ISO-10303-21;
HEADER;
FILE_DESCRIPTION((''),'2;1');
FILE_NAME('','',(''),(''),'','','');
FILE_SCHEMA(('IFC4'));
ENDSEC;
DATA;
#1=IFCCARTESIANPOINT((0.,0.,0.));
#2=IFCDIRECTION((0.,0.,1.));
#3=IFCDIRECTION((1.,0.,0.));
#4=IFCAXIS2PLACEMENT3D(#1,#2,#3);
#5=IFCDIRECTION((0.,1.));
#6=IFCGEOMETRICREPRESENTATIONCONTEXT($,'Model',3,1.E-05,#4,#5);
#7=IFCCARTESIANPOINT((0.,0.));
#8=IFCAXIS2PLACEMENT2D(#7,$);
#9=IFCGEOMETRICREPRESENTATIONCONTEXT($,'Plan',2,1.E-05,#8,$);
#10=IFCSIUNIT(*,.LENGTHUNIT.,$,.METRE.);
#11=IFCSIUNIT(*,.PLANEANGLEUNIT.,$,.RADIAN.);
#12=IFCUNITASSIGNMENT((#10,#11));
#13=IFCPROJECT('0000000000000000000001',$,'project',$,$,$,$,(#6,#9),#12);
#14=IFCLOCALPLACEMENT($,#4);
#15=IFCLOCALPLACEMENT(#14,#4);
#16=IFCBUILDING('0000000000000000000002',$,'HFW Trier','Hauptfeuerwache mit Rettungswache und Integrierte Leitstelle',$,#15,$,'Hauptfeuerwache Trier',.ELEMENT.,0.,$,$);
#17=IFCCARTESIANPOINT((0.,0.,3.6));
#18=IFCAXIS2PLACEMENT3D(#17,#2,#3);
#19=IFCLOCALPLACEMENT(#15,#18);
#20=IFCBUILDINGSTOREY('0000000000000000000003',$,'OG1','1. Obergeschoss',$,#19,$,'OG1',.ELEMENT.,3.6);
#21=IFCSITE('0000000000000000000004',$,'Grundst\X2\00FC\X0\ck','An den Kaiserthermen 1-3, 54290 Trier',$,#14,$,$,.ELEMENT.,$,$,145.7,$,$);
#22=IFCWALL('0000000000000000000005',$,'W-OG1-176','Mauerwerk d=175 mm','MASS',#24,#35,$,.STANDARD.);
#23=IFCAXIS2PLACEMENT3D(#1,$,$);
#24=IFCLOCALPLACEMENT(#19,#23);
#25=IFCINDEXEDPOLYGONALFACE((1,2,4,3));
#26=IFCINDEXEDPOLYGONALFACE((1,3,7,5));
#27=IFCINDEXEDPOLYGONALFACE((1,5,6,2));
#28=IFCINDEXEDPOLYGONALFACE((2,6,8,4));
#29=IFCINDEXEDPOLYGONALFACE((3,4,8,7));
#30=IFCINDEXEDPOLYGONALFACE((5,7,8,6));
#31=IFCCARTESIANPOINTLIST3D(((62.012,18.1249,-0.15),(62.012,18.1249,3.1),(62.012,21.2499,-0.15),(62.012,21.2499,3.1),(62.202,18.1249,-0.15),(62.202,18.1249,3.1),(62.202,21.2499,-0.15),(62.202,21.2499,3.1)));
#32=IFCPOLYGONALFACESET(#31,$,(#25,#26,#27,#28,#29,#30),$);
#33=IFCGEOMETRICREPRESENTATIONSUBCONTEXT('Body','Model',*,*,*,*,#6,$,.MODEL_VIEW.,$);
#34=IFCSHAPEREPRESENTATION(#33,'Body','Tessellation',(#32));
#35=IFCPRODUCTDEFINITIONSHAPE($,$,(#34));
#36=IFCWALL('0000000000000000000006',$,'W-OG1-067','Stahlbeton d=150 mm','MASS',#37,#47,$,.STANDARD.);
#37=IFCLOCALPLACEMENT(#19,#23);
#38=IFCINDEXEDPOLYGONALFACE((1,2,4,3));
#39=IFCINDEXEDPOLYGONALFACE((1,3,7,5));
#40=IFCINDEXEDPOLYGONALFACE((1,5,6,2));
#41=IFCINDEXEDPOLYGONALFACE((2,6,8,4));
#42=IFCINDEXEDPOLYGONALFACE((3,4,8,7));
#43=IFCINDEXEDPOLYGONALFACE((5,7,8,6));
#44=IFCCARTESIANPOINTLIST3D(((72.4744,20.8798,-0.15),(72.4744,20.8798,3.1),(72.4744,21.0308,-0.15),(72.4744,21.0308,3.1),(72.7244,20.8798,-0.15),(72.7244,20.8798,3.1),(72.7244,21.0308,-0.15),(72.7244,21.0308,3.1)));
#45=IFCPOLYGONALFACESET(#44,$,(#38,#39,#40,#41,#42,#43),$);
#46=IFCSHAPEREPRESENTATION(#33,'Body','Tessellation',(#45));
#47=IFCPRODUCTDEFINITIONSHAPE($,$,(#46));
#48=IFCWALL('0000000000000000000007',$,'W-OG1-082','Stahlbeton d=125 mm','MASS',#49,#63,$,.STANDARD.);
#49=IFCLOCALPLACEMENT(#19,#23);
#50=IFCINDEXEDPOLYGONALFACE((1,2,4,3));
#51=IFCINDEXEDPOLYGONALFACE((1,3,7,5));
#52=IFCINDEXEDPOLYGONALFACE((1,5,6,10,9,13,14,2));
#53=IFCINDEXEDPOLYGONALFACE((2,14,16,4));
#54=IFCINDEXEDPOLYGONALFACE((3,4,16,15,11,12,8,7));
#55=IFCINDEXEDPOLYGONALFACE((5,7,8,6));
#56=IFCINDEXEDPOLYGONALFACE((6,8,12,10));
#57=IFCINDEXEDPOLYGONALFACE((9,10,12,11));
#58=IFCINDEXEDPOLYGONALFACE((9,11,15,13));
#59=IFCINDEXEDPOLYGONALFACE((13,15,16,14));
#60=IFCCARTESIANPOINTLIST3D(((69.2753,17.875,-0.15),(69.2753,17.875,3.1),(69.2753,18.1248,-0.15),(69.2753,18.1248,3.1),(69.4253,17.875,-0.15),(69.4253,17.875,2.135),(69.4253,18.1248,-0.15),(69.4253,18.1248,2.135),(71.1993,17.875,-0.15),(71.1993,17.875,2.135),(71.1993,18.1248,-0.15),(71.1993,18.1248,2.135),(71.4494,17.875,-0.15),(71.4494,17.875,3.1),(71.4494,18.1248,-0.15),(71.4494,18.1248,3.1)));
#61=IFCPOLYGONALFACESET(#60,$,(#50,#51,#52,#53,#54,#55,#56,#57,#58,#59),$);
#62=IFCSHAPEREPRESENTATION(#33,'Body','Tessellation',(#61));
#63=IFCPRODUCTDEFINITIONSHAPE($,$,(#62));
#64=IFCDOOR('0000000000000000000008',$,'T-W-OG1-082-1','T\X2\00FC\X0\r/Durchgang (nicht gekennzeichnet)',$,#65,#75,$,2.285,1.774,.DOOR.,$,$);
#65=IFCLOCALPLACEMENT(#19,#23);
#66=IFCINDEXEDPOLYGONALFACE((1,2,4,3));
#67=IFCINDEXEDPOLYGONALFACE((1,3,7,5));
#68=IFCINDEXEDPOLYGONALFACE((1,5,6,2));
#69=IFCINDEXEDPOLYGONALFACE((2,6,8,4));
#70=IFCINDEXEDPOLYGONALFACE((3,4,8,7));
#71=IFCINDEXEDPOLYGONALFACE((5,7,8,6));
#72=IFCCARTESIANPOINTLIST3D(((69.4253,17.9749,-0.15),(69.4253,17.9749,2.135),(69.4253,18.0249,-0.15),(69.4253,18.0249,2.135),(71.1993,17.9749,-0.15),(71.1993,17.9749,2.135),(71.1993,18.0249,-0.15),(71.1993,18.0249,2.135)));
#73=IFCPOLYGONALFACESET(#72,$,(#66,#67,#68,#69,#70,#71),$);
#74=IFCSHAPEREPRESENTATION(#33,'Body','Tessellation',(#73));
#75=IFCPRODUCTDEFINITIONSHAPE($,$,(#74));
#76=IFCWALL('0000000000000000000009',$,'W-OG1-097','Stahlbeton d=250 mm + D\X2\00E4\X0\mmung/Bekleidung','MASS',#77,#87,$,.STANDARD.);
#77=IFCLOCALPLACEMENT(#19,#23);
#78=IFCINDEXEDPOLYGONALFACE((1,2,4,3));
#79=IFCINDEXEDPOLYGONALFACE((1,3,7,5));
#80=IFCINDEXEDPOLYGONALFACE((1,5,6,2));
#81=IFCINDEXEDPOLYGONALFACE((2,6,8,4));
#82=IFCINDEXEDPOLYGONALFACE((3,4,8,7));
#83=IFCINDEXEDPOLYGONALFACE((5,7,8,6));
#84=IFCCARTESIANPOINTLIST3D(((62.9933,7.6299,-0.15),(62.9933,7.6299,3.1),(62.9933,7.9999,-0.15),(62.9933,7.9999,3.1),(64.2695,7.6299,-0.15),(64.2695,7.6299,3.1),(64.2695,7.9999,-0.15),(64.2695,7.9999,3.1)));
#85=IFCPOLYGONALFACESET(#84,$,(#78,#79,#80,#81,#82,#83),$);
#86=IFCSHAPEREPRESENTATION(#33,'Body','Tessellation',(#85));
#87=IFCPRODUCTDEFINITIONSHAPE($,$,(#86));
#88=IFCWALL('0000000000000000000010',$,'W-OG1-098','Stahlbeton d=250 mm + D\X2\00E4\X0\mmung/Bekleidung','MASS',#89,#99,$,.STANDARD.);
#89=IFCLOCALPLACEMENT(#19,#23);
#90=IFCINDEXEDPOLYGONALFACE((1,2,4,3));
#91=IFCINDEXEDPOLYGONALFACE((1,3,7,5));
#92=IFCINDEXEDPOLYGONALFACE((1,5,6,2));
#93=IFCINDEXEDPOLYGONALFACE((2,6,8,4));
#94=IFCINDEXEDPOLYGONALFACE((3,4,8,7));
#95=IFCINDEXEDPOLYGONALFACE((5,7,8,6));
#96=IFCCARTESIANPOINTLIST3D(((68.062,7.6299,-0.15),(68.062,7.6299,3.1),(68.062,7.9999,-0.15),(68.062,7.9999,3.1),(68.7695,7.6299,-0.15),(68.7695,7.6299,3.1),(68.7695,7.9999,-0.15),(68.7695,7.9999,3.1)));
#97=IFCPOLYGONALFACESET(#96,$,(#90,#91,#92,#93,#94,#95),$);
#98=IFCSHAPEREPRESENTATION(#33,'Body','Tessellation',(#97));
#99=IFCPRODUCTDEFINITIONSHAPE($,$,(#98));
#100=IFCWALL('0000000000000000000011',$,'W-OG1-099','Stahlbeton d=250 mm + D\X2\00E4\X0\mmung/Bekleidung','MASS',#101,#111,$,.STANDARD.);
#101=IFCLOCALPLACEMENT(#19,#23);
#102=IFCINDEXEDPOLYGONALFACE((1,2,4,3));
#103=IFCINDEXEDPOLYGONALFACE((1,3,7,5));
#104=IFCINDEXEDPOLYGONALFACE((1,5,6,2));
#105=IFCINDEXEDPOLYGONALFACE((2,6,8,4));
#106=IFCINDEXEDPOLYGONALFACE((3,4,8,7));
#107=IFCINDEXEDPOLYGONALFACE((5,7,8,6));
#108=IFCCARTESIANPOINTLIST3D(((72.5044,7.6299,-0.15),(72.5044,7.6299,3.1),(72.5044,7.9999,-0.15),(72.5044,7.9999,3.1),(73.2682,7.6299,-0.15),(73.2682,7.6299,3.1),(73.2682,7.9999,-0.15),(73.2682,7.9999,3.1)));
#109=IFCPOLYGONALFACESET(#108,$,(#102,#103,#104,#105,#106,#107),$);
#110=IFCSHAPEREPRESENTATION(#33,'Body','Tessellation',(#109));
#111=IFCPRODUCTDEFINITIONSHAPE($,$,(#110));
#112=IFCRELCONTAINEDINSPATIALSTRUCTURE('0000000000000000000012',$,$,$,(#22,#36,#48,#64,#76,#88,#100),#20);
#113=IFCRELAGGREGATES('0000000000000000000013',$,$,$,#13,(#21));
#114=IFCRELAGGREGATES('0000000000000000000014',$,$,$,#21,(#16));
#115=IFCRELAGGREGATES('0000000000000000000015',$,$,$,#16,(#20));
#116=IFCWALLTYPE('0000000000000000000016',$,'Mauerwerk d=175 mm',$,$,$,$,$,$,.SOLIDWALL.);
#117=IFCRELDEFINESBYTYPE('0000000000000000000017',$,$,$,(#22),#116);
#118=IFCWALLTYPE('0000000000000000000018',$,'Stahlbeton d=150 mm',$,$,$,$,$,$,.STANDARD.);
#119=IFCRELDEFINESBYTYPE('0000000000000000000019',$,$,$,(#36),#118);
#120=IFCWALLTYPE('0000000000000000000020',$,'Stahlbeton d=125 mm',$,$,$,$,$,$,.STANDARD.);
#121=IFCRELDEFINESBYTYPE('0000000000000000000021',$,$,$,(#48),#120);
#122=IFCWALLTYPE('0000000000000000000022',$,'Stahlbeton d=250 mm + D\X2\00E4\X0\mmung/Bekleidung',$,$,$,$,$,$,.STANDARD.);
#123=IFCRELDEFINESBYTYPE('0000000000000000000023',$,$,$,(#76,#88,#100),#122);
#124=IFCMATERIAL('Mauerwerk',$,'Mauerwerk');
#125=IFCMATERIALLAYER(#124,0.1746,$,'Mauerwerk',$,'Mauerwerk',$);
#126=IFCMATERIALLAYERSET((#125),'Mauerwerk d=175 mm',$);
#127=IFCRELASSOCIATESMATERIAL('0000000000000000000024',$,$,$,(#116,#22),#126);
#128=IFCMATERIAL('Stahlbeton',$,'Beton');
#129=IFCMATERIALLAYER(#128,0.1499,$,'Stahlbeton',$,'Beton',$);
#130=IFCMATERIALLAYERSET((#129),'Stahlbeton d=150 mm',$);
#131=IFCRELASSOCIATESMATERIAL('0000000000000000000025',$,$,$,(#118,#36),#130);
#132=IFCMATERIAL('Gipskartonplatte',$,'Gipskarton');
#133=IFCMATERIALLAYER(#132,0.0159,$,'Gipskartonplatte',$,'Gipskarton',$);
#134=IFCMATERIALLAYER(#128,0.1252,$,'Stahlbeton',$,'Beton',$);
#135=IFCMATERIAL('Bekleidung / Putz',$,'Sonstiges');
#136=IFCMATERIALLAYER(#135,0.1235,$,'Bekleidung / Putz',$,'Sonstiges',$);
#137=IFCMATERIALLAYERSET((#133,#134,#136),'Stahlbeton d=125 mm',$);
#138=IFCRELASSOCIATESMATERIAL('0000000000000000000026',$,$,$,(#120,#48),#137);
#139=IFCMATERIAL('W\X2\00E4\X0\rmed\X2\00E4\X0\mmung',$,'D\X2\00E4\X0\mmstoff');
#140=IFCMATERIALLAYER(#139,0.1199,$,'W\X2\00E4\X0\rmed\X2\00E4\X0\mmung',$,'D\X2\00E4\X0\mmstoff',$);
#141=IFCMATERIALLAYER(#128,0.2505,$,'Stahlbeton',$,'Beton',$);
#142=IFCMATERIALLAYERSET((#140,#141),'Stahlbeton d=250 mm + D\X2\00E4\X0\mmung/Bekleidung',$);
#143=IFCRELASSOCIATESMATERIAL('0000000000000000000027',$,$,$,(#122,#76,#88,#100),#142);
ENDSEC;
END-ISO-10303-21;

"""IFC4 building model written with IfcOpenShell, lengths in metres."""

from ifc_helpers import new_model, si_unit, direction, frame, frame_2d, origin_with_axes, origin_2d, place, context, subcontext, project, spatial, rectangle, extrude, material, layer, layer_set, layer_usage, type_object, element, fill, save


model = new_model("IFC4")

# Units and contexts
model_context = context("Model", 3, precision=1e-05, world=origin_with_axes(), true_north=direction((0.0, 1.0)))
plan_context = context("Plan", 2, precision=1e-05, world=origin_2d())
body_context = subcontext(model_context, "Body", "Model", "MODEL_VIEW")
ifc_project = project(units=[si_unit("LENGTHUNIT", "METRE"), si_unit("PLANEANGLEUNIT", "RADIAN")], contexts=[model_context, plan_context])

# Site, building, storey
site_placement = place(None, origin_with_axes())
site = spatial("IfcSite", under=ifc_project, at=site_placement, Name="Grundstück", Description="An den Kaiserthermen 1-3, 54290 Trier", CompositionType="ELEMENT", RefElevation=145.7)
building_placement = place(site_placement, origin_with_axes())
building = spatial("IfcBuilding", under=site, at=building_placement, Name="HFW Trier", Description="Hauptfeuerwache mit Rettungswache und Integrierte Leitstelle", LongName="Hauptfeuerwache Trier", CompositionType="ELEMENT", ElevationOfRefHeight=0.0)
storey_placement = place(building_placement, frame((0.0, 0.0, 3.6), z_axis=(0.0, 0.0, 1.0), x_axis=(1.0, 0.0, 0.0)))
storey = spatial("IfcBuildingStorey", under=building, at=storey_placement, Name="OG1", Description="1. Obergeschoss", LongName="OG1", CompositionType="ELEMENT", Elevation=3.6)

# Shared definitions
ifc_material_1 = material(Name="Stahlbeton", Category="Beton")

# Walls
ifc_material_2 = material(Name="Gipskartonplatte", Category="Gipskarton")
ifc_material_3 = material(Name="Mauerwerk", Category="Mauerwerk")
ifc_layer_1 = layer(ifc_material_3, 0.1746, Name="Mauerwerk", Category="Mauerwerk")
ifc_layer_set_1 = layer_set([ifc_layer_1], Name="Mauerwerk d=175 mm")
ifc_layer_usage_1 = layer_usage(ifc_layer_set_1, "AXIS2", "POSITIVE", -0.095)
wall_type_1 = type_object("IfcWallType", Name="Mauerwerk d=175 mm", PredefinedType="SOLIDWALL", material=ifc_layer_set_1)
wall_1_placement = place(storey_placement, frame((62.107, 21.2499, -0.15), z_axis=(0.0, 0.0, 1.0), x_axis=(0.0, -1.0, 0.0)))
element("IfcWall", 1, at=wall_1_placement, inside=storey, type_object=wall_type_1, material=ifc_layer_usage_1, Name="W-OG1-176", Description="Mauerwerk d=175 mm", ObjectType="MASS", PredefinedType="STANDARD", context=body_context, shape_type="SweptSolid", body=[
    extrude(rectangle(XDim=3.125, YDim=0.19, at=frame_2d((1.5625, 0.0))), origin_with_axes(), (0.0, 0.0, 1.0), 3.25),
])
ifc_layer_2 = layer(ifc_material_1, 0.1499, Name="Stahlbeton", Category="Beton")
ifc_layer_set_2 = layer_set([ifc_layer_2], Name="Stahlbeton d=150 mm")
ifc_layer_usage_2 = layer_usage(ifc_layer_set_2, "AXIS2", "POSITIVE", -0.0755)
wall_type_2 = type_object("IfcWallType", Name="Stahlbeton d=150 mm", PredefinedType="STANDARD", material=ifc_layer_set_2)
wall_2_placement = place(storey_placement, frame((72.4744, 20.9553, -0.15), z_axis=(0.0, 0.0, 1.0), x_axis=(1.0, 0.0, 0.0)))
element("IfcWall", 2, at=wall_2_placement, inside=storey, type_object=wall_type_2, material=ifc_layer_usage_2, Name="W-OG1-067", Description="Stahlbeton d=150 mm", ObjectType="MASS", PredefinedType="STANDARD", context=body_context, shape_type="SweptSolid", body=[
    extrude(rectangle(XDim=0.25, YDim=0.151, at=frame_2d((0.125, 0.0))), origin_with_axes(), (0.0, 0.0, 1.0), 3.25),
])

# Wall, opening, door
ifc_layer_3 = layer(ifc_material_2, 0.0159, Name="Gipskartonplatte", Category="Gipskarton")
ifc_layer_4 = layer(ifc_material_1, 0.1252, Name="Stahlbeton", Category="Beton")
ifc_material_4 = material(Name="Bekleidung / Putz", Category="Sonstiges")
ifc_layer_5 = layer(ifc_material_4, 0.1235, Name="Bekleidung / Putz", Category="Sonstiges")
ifc_layer_set_3 = layer_set([ifc_layer_3, ifc_layer_4, ifc_layer_5], Name="Stahlbeton d=125 mm")
ifc_layer_usage_3 = layer_usage(ifc_layer_set_3, "AXIS2", "POSITIVE", -0.125)
wall_type_3 = type_object("IfcWallType", Name="Stahlbeton d=125 mm", PredefinedType="STANDARD", material=ifc_layer_set_3)
wall_3_placement = place(storey_placement, frame((69.2753, 17.9999, -0.15), z_axis=(0.0, 0.0, 1.0), x_axis=(1.0, 0.0, 0.0)))
wall_3 = element("IfcWall", 3, at=wall_3_placement, inside=storey, type_object=wall_type_3, material=ifc_layer_usage_3, Name="W-OG1-082", Description="Stahlbeton d=125 mm", ObjectType="MASS", PredefinedType="STANDARD", context=body_context, shape_type="SweptSolid", body=[
    extrude(rectangle(XDim=2.1741, YDim=0.2499, at=frame_2d((1.087, 0.0))), origin_with_axes(), (0.0, 0.0, 1.0), 3.25),
])
opening_1_placement = place(wall_3_placement, frame((0.15, 0.0, 0.0), z_axis=(0.0, 0.0, 1.0), x_axis=(1.0, 0.0, 0.0)))
opening_1 = element("IfcOpeningElement", 4, at=opening_1_placement, cuts=wall_3, PredefinedType="OPENING", context=body_context, shape_type="SweptSolid", body=[
    extrude(rectangle(XDim=1.774, YDim=0.3499, at=frame_2d((0.887, 0.0))), origin_with_axes(), (0.0, 0.0, 1.0), 2.285),
])
door_1_placement = place(wall_3_placement, frame((0.15, 0.0, 0.0), z_axis=(0.0, 0.0, 1.0), x_axis=(1.0, 0.0, 0.0)))
door_1 = element("IfcDoor", 5, at=door_1_placement, inside=storey, Name="T-W-OG1-082-1", Description="Tür/Durchgang (nicht gekennzeichnet)", OverallHeight=2.285, OverallWidth=1.774, PredefinedType="DOOR", context=body_context, shape_type="SweptSolid", body=[
    extrude(rectangle(XDim=1.774, YDim=0.05, at=frame_2d((0.887, 0.0))), origin_with_axes(), (0.0, 0.0, 1.0), 2.285),
])
fill(opening_1, door_1)

# Walls
ifc_material_5 = material(Name="Wärmedämmung", Category="Dämmstoff")
ifc_layer_6 = layer(ifc_material_5, 0.1199, Name="Wärmedämmung", Category="Dämmstoff")
ifc_layer_7 = layer(ifc_material_1, 0.2505, Name="Stahlbeton", Category="Beton")
ifc_layer_set_4 = layer_set([ifc_layer_6, ifc_layer_7], Name="Stahlbeton d=250 mm + Dämmung/Bekleidung")
ifc_layer_usage_4 = layer_usage(ifc_layer_set_4, "AXIS2", "POSITIVE", -0.185)
wall_type_4 = type_object("IfcWallType", Name="Stahlbeton d=250 mm + Dämmung/Bekleidung", PredefinedType="STANDARD", material=ifc_layer_set_4)
wall_4_placement = place(storey_placement, frame((62.9933, 7.8149, -0.15), z_axis=(0.0, 0.0, 1.0), x_axis=(1.0, 0.0, 0.0)))
element("IfcWall", 6, at=wall_4_placement, inside=storey, type_object=wall_type_4, material=ifc_layer_usage_4, Name="W-OG1-097", Description="Stahlbeton d=250 mm + Dämmung/Bekleidung", ObjectType="MASS", PredefinedType="STANDARD", context=body_context, shape_type="SweptSolid", body=[
    extrude(rectangle(XDim=1.2762, YDim=0.37, at=frame_2d((0.6381, 0.0))), origin_with_axes(), (0.0, 0.0, 1.0), 3.25),
])
ifc_layer_usage_5 = layer_usage(ifc_layer_set_4, "AXIS2", "POSITIVE", -0.185)
wall_5_placement = place(storey_placement, frame((68.062, 7.8149, -0.15), z_axis=(0.0, 0.0, 1.0), x_axis=(1.0, 0.0, 0.0)))
element("IfcWall", 7, at=wall_5_placement, inside=storey, type_object=wall_type_4, material=ifc_layer_usage_5, Name="W-OG1-098", Description="Stahlbeton d=250 mm + Dämmung/Bekleidung", ObjectType="MASS", PredefinedType="STANDARD", context=body_context, shape_type="SweptSolid", body=[
    extrude(rectangle(XDim=0.7075, YDim=0.37, at=frame_2d((0.3537, 0.0))), origin_with_axes(), (0.0, 0.0, 1.0), 3.25),
])
ifc_layer_usage_6 = layer_usage(ifc_layer_set_4, "AXIS2", "POSITIVE", -0.185)
wall_6_placement = place(storey_placement, frame((72.5044, 7.8149, -0.15), z_axis=(0.0, 0.0, 1.0), x_axis=(1.0, 0.0, 0.0)))
element("IfcWall", 8, at=wall_6_placement, inside=storey, type_object=wall_type_4, material=ifc_layer_usage_6, Name="W-OG1-099", Description="Stahlbeton d=250 mm + Dämmung/Bekleidung", ObjectType="MASS", PredefinedType="STANDARD", context=body_context, shape_type="SweptSolid", body=[
    extrude(rectangle(XDim=0.7638, YDim=0.37, at=frame_2d((0.3819, 0.0))), origin_with_axes(), (0.0, 0.0, 1.0), 3.25),
])

save(model, "model.ifc")
